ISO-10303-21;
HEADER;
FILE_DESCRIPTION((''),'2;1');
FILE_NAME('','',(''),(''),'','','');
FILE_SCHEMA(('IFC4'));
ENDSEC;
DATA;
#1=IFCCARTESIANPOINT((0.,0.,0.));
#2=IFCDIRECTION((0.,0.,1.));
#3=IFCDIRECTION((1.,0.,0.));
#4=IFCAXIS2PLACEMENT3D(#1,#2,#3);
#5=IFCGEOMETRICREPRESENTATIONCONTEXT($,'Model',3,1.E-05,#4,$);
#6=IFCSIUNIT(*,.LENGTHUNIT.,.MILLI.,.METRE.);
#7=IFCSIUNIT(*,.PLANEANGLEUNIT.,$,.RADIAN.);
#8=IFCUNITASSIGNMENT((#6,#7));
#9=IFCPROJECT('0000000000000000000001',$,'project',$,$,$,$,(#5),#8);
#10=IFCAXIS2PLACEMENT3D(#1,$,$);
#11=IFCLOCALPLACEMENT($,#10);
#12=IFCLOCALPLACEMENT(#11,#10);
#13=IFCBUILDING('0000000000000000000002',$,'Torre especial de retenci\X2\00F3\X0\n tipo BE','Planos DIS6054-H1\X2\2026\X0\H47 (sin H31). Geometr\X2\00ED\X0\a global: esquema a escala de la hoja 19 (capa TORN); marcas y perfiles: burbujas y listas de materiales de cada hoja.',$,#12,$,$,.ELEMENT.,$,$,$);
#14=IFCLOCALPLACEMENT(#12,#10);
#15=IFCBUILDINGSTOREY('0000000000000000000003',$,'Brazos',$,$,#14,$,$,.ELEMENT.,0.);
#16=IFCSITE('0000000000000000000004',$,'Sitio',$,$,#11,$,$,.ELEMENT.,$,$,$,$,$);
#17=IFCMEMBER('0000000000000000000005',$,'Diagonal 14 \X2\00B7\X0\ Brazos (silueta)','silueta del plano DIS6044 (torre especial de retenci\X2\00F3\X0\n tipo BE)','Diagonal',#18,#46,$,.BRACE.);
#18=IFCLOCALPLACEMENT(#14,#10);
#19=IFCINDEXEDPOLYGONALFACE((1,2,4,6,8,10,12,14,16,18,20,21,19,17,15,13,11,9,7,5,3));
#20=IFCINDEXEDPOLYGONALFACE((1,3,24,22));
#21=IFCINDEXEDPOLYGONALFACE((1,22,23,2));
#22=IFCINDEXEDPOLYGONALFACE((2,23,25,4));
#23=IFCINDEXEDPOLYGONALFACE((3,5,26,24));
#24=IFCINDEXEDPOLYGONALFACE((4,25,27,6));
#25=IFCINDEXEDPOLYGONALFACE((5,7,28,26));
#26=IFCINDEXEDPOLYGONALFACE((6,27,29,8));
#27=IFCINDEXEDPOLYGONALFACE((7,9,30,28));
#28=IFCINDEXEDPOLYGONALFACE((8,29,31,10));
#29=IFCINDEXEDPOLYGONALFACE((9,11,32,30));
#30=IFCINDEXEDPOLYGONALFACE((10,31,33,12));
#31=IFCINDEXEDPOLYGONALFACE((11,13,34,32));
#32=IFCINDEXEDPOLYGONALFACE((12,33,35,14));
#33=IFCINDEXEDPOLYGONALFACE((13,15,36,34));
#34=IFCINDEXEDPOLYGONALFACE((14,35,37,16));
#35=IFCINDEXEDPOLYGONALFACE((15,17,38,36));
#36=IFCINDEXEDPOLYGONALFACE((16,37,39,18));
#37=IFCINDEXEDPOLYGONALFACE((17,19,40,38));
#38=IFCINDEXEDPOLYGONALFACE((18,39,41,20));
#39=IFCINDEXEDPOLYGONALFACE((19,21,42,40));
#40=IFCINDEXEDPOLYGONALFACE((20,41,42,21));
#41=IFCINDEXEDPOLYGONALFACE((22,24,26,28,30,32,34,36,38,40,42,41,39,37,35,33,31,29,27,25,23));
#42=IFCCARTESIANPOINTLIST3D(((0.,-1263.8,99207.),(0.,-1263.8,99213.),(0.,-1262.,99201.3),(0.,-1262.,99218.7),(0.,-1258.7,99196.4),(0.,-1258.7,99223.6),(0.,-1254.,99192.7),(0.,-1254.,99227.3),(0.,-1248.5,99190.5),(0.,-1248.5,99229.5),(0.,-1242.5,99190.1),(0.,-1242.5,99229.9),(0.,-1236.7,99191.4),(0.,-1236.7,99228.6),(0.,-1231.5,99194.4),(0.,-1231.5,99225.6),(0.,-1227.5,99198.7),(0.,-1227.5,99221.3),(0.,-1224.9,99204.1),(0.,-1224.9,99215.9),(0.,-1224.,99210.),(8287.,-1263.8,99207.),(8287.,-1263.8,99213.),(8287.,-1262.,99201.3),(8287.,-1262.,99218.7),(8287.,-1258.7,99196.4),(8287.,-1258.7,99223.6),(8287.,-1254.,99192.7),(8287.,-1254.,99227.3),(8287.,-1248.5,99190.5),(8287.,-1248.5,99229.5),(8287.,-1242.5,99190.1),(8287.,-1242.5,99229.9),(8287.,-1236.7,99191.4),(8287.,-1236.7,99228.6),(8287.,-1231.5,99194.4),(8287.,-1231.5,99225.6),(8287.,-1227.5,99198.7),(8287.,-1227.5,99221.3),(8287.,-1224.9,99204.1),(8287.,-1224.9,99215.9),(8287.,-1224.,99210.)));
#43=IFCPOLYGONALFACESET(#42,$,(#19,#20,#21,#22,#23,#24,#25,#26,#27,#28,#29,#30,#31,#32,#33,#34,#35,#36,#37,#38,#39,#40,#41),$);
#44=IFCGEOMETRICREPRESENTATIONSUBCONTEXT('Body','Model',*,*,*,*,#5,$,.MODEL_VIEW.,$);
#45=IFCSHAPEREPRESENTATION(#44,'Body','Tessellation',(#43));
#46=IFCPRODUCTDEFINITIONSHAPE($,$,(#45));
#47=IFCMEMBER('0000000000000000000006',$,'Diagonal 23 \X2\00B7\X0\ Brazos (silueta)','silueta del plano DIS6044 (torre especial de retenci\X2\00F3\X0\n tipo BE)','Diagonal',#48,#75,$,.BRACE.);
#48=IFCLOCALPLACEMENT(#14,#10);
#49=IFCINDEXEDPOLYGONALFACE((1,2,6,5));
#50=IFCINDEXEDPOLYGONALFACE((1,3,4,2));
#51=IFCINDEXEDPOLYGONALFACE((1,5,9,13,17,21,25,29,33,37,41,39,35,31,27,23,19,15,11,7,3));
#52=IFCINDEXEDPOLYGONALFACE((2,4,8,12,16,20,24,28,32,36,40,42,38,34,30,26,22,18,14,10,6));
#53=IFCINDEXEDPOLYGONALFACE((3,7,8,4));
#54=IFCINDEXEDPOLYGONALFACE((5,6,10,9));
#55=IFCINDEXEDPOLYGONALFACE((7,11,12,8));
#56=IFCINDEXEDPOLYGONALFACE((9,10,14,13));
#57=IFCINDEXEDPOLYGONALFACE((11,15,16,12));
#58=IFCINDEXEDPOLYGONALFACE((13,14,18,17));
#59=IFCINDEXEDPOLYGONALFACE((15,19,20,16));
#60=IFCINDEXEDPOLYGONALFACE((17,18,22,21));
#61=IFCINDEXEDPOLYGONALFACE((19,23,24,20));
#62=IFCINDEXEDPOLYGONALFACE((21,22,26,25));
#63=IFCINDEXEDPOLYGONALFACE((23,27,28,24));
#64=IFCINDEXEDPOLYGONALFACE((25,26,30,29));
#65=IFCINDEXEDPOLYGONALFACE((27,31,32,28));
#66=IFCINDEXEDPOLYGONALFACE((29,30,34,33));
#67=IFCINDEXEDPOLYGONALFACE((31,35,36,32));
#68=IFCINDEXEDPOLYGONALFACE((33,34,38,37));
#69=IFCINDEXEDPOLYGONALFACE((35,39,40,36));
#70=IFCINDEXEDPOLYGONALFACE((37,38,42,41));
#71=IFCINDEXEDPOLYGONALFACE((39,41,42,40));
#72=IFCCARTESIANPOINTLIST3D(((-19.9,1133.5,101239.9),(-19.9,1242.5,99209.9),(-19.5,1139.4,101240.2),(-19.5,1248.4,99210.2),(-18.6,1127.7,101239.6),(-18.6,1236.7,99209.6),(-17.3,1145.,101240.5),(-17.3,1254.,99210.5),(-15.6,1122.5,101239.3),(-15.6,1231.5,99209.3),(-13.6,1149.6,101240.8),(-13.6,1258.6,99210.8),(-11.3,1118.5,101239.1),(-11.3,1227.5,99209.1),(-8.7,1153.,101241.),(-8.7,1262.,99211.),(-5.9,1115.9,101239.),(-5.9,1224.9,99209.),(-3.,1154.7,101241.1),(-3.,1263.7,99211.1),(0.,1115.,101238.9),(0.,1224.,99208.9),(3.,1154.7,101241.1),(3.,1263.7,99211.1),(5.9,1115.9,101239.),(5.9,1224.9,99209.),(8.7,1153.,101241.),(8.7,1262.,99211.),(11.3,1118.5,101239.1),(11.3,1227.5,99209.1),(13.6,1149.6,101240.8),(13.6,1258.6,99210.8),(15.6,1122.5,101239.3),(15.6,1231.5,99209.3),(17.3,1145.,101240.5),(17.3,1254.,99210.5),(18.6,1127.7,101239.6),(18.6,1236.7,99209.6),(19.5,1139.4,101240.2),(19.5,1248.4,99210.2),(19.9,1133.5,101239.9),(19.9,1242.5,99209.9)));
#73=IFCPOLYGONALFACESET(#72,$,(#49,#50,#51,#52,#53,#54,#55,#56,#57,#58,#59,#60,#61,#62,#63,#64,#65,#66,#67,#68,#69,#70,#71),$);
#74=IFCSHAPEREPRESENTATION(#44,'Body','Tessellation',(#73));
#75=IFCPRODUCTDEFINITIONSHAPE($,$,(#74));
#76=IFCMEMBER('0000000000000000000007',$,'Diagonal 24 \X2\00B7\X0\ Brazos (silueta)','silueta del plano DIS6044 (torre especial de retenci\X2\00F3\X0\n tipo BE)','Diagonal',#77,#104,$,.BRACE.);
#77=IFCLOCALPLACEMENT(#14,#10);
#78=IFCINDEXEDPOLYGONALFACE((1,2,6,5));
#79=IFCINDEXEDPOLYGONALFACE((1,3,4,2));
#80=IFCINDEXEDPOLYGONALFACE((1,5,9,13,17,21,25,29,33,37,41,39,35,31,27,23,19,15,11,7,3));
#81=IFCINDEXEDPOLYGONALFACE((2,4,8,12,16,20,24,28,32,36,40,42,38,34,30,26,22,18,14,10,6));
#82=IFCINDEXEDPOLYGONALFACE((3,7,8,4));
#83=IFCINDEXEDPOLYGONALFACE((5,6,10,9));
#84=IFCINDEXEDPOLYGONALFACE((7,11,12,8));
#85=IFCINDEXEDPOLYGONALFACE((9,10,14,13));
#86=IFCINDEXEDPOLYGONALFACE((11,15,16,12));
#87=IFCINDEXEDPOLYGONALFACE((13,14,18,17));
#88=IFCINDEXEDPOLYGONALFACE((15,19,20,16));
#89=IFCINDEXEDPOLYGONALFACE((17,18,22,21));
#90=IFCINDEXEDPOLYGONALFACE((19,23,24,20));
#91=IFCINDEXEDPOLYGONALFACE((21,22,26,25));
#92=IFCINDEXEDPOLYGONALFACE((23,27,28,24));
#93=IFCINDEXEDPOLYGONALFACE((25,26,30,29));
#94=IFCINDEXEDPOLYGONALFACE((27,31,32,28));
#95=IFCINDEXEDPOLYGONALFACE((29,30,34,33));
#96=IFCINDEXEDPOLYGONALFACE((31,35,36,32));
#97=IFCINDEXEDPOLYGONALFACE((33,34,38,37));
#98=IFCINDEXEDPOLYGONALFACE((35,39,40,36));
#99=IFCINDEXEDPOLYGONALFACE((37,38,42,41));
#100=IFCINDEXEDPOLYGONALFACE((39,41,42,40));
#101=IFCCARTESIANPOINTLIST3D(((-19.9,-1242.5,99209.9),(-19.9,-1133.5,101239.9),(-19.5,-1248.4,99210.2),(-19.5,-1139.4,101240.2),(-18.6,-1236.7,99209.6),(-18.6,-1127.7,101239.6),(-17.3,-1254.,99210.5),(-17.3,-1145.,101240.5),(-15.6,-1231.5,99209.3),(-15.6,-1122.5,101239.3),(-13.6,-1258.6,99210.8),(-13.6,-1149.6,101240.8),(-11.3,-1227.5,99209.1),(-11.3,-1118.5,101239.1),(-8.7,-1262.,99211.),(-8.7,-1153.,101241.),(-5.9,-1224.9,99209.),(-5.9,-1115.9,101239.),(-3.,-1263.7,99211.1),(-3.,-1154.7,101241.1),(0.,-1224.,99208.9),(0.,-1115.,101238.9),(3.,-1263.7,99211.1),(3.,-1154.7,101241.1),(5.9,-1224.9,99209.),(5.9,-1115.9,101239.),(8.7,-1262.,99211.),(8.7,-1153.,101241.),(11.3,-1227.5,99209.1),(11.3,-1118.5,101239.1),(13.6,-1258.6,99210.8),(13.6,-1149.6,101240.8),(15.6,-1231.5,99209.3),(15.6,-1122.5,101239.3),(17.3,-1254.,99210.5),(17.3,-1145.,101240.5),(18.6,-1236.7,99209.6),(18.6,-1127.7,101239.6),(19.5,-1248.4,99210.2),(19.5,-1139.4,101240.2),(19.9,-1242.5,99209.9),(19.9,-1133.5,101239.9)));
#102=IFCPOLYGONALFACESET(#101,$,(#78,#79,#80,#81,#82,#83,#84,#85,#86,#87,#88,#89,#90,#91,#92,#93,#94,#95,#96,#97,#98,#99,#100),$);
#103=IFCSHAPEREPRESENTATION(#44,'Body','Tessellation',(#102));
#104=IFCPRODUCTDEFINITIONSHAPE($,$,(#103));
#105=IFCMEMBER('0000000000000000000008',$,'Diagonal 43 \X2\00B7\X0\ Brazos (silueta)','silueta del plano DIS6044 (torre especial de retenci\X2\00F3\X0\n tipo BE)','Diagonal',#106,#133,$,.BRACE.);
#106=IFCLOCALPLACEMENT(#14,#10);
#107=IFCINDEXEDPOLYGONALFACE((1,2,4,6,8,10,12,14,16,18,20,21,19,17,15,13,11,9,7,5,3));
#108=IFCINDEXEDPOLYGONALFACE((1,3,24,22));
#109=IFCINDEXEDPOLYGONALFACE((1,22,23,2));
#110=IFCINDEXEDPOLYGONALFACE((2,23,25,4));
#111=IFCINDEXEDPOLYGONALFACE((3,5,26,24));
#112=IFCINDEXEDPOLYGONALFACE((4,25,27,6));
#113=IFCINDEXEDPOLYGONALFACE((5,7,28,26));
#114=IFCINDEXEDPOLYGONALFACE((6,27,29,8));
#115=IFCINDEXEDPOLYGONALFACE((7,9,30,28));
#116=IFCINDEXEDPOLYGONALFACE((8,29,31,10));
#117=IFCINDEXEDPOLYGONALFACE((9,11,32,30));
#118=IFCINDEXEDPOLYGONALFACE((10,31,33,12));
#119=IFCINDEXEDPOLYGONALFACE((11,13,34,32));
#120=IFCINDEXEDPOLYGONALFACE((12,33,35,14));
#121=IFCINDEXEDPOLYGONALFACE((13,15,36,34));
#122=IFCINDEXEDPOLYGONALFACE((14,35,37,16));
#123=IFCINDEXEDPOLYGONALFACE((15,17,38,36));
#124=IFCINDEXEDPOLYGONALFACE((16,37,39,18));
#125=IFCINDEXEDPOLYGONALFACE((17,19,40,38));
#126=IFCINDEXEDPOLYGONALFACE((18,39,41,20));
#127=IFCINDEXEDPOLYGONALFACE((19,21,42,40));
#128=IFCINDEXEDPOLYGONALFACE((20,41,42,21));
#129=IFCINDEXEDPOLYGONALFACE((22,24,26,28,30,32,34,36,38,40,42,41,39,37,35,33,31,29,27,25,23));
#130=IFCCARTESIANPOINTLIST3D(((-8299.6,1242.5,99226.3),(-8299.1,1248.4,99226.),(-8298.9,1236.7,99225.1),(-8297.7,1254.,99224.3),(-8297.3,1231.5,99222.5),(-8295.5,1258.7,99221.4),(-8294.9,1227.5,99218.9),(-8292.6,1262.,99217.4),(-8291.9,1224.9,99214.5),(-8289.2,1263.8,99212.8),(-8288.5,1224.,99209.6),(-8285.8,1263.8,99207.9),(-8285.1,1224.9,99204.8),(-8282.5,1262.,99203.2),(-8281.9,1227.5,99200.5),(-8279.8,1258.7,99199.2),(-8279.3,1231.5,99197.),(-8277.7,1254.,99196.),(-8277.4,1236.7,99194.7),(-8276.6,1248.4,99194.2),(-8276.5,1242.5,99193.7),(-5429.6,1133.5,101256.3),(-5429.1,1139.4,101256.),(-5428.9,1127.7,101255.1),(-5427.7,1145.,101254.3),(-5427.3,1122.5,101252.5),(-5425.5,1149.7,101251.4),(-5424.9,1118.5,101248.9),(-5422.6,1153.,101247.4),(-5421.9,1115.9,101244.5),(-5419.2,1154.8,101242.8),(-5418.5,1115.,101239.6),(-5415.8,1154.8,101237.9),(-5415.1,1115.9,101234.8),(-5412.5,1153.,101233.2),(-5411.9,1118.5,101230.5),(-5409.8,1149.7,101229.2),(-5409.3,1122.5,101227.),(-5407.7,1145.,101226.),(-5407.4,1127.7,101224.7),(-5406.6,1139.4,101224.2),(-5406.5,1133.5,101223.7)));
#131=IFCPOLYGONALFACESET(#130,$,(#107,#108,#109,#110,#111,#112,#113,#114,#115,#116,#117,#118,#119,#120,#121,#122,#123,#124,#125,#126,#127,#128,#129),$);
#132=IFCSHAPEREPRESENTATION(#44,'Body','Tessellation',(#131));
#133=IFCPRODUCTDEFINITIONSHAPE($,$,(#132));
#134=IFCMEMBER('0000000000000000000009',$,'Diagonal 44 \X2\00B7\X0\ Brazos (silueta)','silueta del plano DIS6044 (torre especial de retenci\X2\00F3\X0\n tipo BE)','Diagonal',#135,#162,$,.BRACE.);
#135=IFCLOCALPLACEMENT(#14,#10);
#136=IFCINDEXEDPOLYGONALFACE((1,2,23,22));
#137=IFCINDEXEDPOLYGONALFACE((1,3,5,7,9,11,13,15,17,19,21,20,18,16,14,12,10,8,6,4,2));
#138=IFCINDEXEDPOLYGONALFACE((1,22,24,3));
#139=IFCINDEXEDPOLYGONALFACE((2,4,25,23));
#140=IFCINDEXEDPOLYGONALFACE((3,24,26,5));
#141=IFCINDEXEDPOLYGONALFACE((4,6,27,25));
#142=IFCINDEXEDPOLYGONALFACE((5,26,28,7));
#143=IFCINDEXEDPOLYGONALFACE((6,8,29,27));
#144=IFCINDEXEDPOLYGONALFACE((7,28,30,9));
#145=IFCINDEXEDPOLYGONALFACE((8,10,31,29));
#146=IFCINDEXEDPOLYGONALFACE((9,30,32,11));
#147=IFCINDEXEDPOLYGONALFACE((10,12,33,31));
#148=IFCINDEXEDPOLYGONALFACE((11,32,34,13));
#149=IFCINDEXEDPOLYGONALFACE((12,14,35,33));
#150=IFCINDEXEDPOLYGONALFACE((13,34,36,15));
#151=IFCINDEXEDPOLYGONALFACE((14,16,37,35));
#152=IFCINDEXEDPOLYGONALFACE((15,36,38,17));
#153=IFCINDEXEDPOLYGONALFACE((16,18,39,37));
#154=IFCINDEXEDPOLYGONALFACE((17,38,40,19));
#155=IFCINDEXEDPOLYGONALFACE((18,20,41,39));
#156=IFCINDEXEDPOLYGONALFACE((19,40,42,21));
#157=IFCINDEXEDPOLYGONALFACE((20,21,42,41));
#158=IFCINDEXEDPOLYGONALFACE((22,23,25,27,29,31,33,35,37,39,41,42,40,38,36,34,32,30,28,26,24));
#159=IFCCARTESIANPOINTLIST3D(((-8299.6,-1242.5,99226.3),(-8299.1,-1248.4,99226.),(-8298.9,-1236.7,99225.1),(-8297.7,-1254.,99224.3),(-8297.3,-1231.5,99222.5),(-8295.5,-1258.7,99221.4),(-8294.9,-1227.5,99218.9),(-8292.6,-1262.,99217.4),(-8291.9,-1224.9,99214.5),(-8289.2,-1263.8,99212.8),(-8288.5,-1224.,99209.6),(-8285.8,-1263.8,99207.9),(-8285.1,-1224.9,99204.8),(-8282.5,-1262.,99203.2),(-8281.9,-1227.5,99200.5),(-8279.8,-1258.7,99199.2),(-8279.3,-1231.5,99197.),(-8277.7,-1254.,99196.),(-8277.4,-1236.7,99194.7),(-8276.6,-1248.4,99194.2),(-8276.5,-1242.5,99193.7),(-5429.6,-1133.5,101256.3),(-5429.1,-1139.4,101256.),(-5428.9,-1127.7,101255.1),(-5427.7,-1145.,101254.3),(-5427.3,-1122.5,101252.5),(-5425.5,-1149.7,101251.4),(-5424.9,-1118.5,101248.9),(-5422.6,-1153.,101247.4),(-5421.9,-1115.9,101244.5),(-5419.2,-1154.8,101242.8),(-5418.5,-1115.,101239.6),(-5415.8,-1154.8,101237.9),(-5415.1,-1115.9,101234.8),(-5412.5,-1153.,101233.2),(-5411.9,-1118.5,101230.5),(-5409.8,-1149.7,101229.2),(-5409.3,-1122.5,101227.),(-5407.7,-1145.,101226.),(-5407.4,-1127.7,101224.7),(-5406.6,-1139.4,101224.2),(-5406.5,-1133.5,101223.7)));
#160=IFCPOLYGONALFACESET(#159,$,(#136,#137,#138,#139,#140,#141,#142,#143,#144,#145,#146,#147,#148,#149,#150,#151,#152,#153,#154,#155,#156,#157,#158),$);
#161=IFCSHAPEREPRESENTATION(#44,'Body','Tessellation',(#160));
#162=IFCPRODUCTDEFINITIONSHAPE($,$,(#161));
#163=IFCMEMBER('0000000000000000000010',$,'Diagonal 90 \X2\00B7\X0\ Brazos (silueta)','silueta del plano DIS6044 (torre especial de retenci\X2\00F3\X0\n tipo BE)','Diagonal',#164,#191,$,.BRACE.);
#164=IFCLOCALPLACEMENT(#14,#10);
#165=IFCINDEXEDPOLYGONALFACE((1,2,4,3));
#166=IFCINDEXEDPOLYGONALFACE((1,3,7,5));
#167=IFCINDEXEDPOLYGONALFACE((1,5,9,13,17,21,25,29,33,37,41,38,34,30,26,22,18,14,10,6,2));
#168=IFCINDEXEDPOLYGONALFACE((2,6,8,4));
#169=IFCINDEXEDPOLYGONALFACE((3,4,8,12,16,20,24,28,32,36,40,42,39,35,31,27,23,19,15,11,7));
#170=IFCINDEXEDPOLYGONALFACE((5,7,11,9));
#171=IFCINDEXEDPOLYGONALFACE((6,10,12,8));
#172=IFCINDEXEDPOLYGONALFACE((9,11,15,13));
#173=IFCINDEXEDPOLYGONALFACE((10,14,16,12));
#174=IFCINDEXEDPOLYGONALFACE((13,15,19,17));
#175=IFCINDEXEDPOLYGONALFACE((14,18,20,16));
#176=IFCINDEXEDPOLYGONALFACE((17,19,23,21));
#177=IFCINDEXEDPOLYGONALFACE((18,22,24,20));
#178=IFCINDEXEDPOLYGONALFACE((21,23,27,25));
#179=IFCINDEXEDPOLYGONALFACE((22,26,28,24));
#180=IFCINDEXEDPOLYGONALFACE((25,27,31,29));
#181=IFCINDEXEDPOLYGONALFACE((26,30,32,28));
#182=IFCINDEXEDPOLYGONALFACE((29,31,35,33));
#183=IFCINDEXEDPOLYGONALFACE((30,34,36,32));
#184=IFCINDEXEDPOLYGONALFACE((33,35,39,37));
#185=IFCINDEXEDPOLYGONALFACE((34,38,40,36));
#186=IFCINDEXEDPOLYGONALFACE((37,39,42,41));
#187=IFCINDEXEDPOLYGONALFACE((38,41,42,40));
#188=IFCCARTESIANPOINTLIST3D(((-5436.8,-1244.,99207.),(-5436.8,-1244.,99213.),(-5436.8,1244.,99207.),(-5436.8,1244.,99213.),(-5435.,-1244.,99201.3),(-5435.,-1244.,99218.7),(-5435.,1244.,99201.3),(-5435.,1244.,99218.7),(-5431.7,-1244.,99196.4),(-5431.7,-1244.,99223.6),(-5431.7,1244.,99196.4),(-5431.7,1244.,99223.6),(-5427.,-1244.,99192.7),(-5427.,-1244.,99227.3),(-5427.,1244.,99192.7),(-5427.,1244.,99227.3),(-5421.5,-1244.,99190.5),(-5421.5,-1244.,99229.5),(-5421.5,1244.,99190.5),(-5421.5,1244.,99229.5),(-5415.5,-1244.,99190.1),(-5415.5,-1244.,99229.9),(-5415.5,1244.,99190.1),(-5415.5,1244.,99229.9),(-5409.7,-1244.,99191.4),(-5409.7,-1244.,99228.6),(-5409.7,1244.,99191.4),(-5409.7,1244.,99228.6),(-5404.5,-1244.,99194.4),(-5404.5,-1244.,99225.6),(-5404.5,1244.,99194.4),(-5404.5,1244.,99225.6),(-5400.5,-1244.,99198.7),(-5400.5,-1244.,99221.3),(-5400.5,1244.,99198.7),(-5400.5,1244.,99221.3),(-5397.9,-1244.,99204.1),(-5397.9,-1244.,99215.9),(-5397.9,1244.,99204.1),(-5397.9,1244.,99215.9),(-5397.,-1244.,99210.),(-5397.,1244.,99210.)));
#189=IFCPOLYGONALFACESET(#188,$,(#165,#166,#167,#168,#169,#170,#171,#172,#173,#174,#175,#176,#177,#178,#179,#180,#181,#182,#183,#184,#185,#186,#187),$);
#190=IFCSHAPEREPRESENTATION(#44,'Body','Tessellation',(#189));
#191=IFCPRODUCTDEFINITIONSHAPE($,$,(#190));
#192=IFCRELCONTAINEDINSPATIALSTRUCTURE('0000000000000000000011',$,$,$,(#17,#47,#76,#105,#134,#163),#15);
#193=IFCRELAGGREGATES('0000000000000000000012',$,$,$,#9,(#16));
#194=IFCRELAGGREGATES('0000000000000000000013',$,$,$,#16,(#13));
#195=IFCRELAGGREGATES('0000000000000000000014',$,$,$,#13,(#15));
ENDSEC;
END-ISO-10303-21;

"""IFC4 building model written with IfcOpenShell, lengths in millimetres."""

from ifc_helpers import new_model, si_unit, frame, origin, origin_with_axes, place, context, subcontext, project, spatial, circle, extrude, element, save


model = new_model("IFC4")

# Units and contexts
model_context = context("Model", 3, precision=1e-05, world=origin_with_axes())
body_context = subcontext(model_context, "Body", "Model", "MODEL_VIEW")
ifc_project = project(units=[si_unit("LENGTHUNIT", "METRE", prefix="MILLI"), si_unit("PLANEANGLEUNIT", "RADIAN")], contexts=[model_context])

# Site, building, storey
site_placement = place(None, origin())
site = spatial("IfcSite", under=ifc_project, at=site_placement, Name="Sitio", CompositionType="ELEMENT")
building_placement = place(site_placement, origin())
building = spatial("IfcBuilding", under=site, at=building_placement, Name="Torre especial de retención tipo BE", Description="Planos DIS6054-H1…H47 (sin H31). Geometría global: esquema a escala de la hoja 19 (capa TORN); marcas y perfiles: burbujas y listas de materiales de cada hoja.", CompositionType="ELEMENT")
storey_placement = place(building_placement, origin())
storey = spatial("IfcBuildingStorey", under=building, at=storey_placement, Name="Brazos", CompositionType="ELEMENT", Elevation=0.0)

# Members
for number, where, z_axis, x_axis, name in (
    (1, (0.0, -1244.0, 99210.0), (1.0, 0.0, 0.0), (0.0, 1.0, 0.0), "Diagonal 14 · Brazos (silueta)"),
):
    element("IfcMember", number, at=place(storey_placement, frame(where, z_axis=z_axis, x_axis=x_axis)), inside=storey, Name=name, Description="silueta del plano DIS6044 (torre especial de retención tipo BE)", ObjectType="Diagonal", PredefinedType="BRACE", context=body_context, shape_type="SweptSolid", body=[
        extrude(circle(Radius=20.0), None, (0.0, 0.0, 1.0), 8287.0),
    ])
for number, where, z_axis, x_axis, name in (
    (2, (0.0, 1135.0, 101240.0), (0.0, 0.053617, -0.998562), (0.0, -0.998562, -0.053617), "Diagonal 23 · Brazos (silueta)"),
    (3, (0.0, -1135.0, 101240.0), (0.0, -0.053617, -0.998562), (0.0, 0.998562, -0.053617), "Diagonal 24 · Brazos (silueta)"),
):
    element("IfcMember", number, at=place(storey_placement, frame(where, z_axis=z_axis, x_axis=x_axis)), inside=storey, Name=name, Description="silueta del plano DIS6044 (torre especial de retención tipo BE)", ObjectType="Diagonal", PredefinedType="BRACE", context=body_context, shape_type="SweptSolid", body=[
        extrude(circle(Radius=20.0), None, (0.0, 0.0, 1.0), 2032.9),
    ])
for number, where, z_axis, x_axis, name in (
    (4, (-5418.0, 1135.0, 101240.0), (-0.816023, 0.030992, -0.577187), (-0.025302, -0.99952, -0.017897), "Diagonal 43 · Brazos (silueta)"),
    (5, (-5418.0, -1135.0, 101240.0), (-0.816023, -0.030992, -0.577187), (-0.025302, 0.99952, -0.017897), "Diagonal 44 · Brazos (silueta)"),
):
    element("IfcMember", number, at=place(storey_placement, frame(where, z_axis=z_axis, x_axis=x_axis)), inside=storey, Name=name, Description="silueta del plano DIS6044 (torre especial de retención tipo BE)", ObjectType="Diagonal", PredefinedType="BRACE", context=body_context, shape_type="SweptSolid", body=[
        extrude(circle(Radius=20.0), None, (0.0, 0.0, 1.0), 3517.1),
    ])
member_1_placement = place(storey_placement, frame((-5417.0, 1244.0, 99210.0), z_axis=(0.0, -1.0, 0.0), x_axis=(1.0, 0.0, 0.0)))
element("IfcMember", 6, at=member_1_placement, inside=storey, Name="Diagonal 90 · Brazos (silueta)", Description="silueta del plano DIS6044 (torre especial de retención tipo BE)", ObjectType="Diagonal", PredefinedType="BRACE", context=body_context, shape_type="SweptSolid", body=[
    extrude(circle(Radius=20.0), None, (0.0, 0.0, 1.0), 2488.0),
])

save(model, "model.ifc")
